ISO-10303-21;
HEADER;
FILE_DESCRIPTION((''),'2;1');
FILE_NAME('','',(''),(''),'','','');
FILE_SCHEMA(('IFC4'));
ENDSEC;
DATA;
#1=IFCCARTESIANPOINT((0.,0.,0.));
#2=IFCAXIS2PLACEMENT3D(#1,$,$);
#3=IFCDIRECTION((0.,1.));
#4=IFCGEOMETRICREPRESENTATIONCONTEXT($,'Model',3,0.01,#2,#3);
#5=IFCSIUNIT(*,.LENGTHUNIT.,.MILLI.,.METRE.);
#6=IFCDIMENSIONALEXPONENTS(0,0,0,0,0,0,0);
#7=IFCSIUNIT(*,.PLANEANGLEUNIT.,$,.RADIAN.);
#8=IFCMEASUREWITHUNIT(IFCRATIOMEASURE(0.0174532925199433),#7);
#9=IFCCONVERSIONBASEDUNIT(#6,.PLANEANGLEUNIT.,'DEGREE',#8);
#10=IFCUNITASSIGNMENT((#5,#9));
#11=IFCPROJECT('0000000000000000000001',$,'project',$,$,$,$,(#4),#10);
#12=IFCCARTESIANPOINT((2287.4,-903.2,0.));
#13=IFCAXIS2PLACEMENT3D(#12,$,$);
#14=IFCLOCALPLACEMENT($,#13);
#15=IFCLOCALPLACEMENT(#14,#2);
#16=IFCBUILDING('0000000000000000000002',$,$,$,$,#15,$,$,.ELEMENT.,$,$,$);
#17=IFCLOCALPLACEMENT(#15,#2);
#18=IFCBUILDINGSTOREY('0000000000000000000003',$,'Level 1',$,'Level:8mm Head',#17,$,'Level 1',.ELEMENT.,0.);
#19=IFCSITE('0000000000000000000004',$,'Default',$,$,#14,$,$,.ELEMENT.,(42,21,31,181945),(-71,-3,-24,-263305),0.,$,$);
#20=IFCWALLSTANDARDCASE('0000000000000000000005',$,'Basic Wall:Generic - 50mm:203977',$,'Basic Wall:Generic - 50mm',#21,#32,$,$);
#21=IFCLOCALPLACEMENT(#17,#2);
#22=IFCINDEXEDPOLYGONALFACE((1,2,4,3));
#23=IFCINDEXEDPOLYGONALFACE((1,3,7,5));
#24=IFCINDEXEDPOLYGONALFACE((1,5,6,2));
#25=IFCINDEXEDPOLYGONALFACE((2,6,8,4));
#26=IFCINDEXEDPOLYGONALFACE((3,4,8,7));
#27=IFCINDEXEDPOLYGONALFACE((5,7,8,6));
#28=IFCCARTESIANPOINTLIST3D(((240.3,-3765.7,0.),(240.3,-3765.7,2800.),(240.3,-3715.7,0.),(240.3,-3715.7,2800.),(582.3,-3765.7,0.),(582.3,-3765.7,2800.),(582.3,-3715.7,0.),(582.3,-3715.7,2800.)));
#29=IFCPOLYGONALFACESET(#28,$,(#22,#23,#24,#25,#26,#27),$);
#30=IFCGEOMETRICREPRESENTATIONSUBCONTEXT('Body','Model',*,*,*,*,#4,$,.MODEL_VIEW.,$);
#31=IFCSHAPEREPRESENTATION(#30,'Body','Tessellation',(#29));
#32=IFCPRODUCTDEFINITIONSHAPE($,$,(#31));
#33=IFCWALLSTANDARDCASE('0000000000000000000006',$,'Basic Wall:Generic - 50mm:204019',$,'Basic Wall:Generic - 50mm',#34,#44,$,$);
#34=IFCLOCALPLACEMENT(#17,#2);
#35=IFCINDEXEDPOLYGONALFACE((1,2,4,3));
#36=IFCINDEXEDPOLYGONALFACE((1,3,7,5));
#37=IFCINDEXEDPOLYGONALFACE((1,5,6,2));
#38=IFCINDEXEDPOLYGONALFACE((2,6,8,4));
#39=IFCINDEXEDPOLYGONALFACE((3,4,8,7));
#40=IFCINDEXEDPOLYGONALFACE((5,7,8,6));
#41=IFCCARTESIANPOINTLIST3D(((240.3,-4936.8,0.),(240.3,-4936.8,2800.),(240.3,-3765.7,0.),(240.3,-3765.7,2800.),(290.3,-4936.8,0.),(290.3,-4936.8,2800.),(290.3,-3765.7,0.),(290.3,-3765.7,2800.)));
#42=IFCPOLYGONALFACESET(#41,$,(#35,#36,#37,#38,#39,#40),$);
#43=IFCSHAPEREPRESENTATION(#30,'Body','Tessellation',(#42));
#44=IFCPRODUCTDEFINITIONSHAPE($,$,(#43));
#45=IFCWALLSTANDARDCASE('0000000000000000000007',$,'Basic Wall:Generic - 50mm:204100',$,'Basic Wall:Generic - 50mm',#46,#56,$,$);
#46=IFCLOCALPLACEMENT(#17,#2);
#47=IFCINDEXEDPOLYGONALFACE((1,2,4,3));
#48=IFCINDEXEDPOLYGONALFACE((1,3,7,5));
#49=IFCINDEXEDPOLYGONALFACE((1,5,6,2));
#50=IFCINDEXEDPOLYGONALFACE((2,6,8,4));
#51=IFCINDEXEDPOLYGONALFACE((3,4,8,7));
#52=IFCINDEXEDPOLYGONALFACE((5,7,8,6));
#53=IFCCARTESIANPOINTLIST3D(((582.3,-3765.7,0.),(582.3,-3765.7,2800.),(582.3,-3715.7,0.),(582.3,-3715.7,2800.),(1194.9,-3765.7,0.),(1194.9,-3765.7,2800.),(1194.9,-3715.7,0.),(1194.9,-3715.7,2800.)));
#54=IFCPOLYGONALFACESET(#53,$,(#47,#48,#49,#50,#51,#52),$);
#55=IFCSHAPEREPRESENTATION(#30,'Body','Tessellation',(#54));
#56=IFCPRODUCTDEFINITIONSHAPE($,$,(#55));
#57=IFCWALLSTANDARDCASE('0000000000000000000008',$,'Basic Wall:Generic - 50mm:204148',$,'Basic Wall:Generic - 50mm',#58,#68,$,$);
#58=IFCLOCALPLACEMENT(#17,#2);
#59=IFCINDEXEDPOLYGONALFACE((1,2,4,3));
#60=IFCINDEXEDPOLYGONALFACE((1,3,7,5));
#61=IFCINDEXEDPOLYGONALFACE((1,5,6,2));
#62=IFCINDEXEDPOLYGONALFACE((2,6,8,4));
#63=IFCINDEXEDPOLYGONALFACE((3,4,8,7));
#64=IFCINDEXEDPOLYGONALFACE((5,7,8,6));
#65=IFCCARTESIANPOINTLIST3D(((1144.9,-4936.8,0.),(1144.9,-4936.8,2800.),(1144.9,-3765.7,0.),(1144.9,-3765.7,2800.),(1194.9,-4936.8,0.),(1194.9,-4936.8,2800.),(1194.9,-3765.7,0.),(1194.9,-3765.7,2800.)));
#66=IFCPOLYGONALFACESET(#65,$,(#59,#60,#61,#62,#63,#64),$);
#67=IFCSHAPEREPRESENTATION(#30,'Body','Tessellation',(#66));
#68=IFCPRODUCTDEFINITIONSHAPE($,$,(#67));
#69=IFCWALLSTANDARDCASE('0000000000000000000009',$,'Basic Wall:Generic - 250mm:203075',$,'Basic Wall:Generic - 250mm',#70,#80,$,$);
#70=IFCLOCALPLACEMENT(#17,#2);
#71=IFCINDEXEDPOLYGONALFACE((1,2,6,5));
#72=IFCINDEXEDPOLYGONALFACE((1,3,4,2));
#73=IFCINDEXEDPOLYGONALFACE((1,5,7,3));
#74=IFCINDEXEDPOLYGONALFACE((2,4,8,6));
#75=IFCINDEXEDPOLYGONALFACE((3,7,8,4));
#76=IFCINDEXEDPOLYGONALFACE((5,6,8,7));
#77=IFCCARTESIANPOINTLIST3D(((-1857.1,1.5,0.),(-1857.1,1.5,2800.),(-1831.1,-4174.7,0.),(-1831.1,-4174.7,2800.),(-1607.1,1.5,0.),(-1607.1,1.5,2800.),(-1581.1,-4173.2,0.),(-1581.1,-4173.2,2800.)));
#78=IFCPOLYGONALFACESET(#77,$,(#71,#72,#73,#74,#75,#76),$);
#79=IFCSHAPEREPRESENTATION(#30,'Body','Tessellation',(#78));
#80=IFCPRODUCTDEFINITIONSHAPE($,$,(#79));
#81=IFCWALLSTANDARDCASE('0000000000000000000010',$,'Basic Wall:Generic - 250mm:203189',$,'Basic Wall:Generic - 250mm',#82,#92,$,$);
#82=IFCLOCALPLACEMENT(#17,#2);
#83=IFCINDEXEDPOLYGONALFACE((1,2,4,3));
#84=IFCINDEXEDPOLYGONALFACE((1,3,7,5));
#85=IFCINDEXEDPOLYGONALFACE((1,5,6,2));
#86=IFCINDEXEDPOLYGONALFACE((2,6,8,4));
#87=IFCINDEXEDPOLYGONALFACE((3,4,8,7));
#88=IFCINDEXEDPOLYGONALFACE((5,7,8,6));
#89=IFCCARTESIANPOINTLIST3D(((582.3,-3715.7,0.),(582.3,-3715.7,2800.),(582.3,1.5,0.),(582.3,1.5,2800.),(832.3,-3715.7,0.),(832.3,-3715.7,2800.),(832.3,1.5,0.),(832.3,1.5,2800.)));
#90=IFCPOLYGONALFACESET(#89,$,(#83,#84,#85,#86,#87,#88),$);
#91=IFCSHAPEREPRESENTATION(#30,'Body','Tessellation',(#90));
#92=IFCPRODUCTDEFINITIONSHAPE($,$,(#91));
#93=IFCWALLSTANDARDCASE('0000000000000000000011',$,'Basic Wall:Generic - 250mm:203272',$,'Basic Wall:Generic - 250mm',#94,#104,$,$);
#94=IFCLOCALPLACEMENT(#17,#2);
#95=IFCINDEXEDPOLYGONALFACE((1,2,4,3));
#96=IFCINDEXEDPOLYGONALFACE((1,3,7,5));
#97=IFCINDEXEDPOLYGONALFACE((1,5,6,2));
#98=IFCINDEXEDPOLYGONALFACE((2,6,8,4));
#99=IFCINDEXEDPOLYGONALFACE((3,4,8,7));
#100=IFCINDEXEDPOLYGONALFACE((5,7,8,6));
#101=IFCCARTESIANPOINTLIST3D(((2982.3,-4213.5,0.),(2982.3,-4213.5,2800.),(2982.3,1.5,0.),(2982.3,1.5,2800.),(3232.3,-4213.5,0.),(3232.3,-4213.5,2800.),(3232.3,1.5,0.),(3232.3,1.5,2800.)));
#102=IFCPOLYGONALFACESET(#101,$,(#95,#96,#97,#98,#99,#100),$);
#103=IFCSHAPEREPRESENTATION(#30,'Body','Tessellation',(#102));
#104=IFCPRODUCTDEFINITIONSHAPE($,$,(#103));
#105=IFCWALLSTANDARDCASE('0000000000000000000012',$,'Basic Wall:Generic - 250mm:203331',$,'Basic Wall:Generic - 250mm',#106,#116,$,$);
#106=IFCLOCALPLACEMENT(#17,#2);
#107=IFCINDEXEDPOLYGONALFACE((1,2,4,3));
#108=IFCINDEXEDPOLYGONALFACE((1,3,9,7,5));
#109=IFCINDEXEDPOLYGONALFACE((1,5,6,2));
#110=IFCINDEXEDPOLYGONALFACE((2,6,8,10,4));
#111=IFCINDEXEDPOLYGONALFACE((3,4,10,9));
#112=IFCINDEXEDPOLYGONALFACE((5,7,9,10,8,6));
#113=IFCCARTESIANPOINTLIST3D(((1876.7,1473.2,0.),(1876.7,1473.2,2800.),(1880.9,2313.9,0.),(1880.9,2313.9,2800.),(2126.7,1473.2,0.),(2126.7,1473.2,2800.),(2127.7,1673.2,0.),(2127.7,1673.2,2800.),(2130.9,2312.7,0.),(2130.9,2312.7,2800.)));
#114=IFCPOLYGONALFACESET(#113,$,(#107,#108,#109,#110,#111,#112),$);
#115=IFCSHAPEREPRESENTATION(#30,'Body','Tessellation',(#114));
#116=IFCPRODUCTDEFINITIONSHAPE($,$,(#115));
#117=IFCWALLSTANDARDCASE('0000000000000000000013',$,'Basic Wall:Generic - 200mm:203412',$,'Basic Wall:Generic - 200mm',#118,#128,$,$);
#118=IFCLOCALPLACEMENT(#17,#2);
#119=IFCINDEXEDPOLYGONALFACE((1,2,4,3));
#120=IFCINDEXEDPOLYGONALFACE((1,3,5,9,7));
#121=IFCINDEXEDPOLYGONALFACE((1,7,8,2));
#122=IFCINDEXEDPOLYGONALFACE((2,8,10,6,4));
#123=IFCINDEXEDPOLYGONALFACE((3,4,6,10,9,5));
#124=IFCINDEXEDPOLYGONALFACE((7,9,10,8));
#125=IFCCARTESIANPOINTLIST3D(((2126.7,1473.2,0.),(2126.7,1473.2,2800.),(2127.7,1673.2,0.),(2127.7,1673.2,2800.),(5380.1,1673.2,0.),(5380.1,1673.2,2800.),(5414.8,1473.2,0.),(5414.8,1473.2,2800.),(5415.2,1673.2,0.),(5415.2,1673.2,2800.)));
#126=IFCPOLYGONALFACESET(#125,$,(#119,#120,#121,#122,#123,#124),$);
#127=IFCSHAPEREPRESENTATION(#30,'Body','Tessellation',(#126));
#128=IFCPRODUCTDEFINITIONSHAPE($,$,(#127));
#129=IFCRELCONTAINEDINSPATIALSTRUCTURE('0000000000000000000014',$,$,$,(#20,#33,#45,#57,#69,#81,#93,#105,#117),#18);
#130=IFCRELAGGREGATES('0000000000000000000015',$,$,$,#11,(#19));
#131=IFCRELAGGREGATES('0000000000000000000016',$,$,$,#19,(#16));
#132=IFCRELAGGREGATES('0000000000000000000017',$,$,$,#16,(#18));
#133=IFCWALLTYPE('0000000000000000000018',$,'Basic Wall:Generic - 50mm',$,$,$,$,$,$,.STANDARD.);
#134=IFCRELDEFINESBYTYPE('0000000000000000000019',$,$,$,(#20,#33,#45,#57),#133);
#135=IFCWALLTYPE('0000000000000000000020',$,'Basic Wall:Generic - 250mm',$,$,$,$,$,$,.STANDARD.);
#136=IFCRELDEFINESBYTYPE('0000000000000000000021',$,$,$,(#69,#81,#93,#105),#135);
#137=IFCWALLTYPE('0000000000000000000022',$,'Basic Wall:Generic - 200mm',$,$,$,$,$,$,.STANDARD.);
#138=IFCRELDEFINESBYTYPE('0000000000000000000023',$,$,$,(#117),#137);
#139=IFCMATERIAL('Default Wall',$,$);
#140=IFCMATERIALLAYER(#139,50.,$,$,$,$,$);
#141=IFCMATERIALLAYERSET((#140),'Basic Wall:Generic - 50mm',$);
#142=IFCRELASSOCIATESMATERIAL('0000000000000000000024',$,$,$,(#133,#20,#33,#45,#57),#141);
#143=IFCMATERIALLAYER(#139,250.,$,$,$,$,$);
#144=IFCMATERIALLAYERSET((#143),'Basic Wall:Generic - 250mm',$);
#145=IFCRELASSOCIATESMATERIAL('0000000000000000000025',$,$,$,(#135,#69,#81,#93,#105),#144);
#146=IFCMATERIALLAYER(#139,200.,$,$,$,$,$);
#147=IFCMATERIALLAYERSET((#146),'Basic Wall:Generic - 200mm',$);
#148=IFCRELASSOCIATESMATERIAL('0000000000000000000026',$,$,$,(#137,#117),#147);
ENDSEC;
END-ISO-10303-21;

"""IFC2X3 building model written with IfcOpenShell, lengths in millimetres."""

from ifc_helpers import new_model, entity, si_unit, converted_unit, direction, frame, frame_2d, origin, place, context, subcontext, project, spatial, polyline, rectangle, outline, extrude, material, layer, layer_set, layer_usage, type_object, element, save


model = new_model("IFC2X3")

# Units and contexts
model_context = context("Model", 3, precision=0.01, world=origin(), true_north=direction((0.0, 1.0)))
body_context = subcontext(model_context, "Body", "Model", "MODEL_VIEW")
ifc_project = project(units=[si_unit("LENGTHUNIT", "METRE", prefix="MILLI"), converted_unit("PLANEANGLEUNIT", "DEGREE", entity("IfcRatioMeasure", 0.0174532925199433), si_unit("PLANEANGLEUNIT", "RADIAN"), dimensions=[0, 0, 0, 0, 0, 0, 0])], contexts=[model_context])

# Site, building, storey
site_placement = place(None, frame((2287.4, -903.2, 0.0)))
site = spatial("IfcSite", under=ifc_project, at=site_placement, Name="Default", CompositionType="ELEMENT", RefLatitude=(42, 21, 31, 181945), RefLongitude=(-71, -3, -24, -263305), RefElevation=0.0)
building_placement = place(site_placement, origin())
building = spatial("IfcBuilding", under=site, at=building_placement, CompositionType="ELEMENT")
storey_placement = place(building_placement, origin())
storey = spatial("IfcBuildingStorey", under=building, at=storey_placement, Name="Level 1", ObjectType="Level:8mm Head", LongName="Level 1", CompositionType="ELEMENT", Elevation=0.0)

# Walls
ifc_material_1 = material(Name="Default Wall")
ifc_layer_1 = layer(ifc_material_1, 50.0)
ifc_layer_set_1 = layer_set([ifc_layer_1], Name="Basic Wall:Generic - 50mm")
wall_type_1 = type_object("IfcWallType", Name="Basic Wall:Generic - 50mm", PredefinedType="STANDARD", material=ifc_layer_set_1)
ifc_layer_usage_1 = layer_usage(ifc_layer_set_1, "AXIS2", "POSITIVE", -25.0)
wall_1_placement = place(storey_placement, frame((582.3, -3740.7, 0.0), z_axis=(0.0, 0.0, 1.0), x_axis=(-1.0, 0.0, 0.0)))
element("IfcWallStandardCase", 1, at=wall_1_placement, inside=storey, type_object=wall_type_1, material=ifc_layer_usage_1, Name="Basic Wall:Generic - 50mm:203977", ObjectType="Basic Wall:Generic - 50mm", context=body_context, shape_type="SweptSolid", body=[
    extrude(rectangle(XDim=342.1, YDim=50.0, at=frame_2d((171.0, 0.0), x_axis=(-1.0, 0.0))), origin(), (0.0, 0.0, 1.0), 2800.0),
])
ifc_layer_usage_2 = layer_usage(ifc_layer_set_1, "AXIS2", "POSITIVE", -25.0)
wall_2_placement = place(storey_placement, frame((265.3, -3765.7, 0.0), z_axis=(0.0, 0.0, 1.0), x_axis=(0.0, -1.0, 0.0)))
element("IfcWallStandardCase", 2, at=wall_2_placement, inside=storey, type_object=wall_type_1, material=ifc_layer_usage_2, Name="Basic Wall:Generic - 50mm:204019", ObjectType="Basic Wall:Generic - 50mm", context=body_context, shape_type="SweptSolid", body=[
    extrude(rectangle(XDim=1171.1, YDim=50.0, at=frame_2d((585.5, 0.0), x_axis=(-1.0, 0.0))), origin(), (0.0, 0.0, 1.0), 2800.0),
])
ifc_layer_usage_3 = layer_usage(ifc_layer_set_1, "AXIS2", "POSITIVE", -25.0)
wall_3_placement = place(storey_placement, frame((582.3, -3740.7, 0.0)))
element("IfcWallStandardCase", 3, at=wall_3_placement, inside=storey, type_object=wall_type_1, material=ifc_layer_usage_3, Name="Basic Wall:Generic - 50mm:204100", ObjectType="Basic Wall:Generic - 50mm", context=body_context, shape_type="SweptSolid", body=[
    extrude(rectangle(XDim=612.6, YDim=50.0, at=frame_2d((306.3, 0.0), x_axis=(-1.0, 0.0))), origin(), (0.0, 0.0, 1.0), 2800.0),
])
ifc_layer_usage_4 = layer_usage(ifc_layer_set_1, "AXIS2", "NEGATIVE", 25.0)
wall_4_placement = place(storey_placement, frame((1169.9, -3765.7, 0.0), z_axis=(0.0, 0.0, 1.0), x_axis=(0.0, -1.0, 0.0)))
element("IfcWallStandardCase", 4, at=wall_4_placement, inside=storey, type_object=wall_type_1, material=ifc_layer_usage_4, Name="Basic Wall:Generic - 50mm:204148", ObjectType="Basic Wall:Generic - 50mm", context=body_context, shape_type="SweptSolid", body=[
    extrude(rectangle(XDim=1171.1, YDim=50.0, at=frame_2d((585.5, 0.0), x_axis=(-1.0, 0.0))), origin(), (0.0, 0.0, 1.0), 2800.0),
])
ifc_layer_2 = layer(ifc_material_1, 250.0)
ifc_layer_set_2 = layer_set([ifc_layer_2], Name="Basic Wall:Generic - 250mm")
ifc_layer_usage_5 = layer_usage(ifc_layer_set_2, "AXIS2", "POSITIVE", -125.0)
wall_type_2 = type_object("IfcWallType", Name="Basic Wall:Generic - 250mm", PredefinedType="STANDARD", material=ifc_layer_set_2)
wall_5_placement = place(storey_placement, frame((-1732.1, 2.3, 0.0), z_axis=(0.0, 0.0, 1.0), x_axis=(0.006231, -0.999981, 0.0)))
element("IfcWallStandardCase", 5, at=wall_5_placement, inside=storey, type_object=wall_type_2, material=ifc_layer_usage_5, Name="Basic Wall:Generic - 250mm:203075", ObjectType="Basic Wall:Generic - 250mm", context=body_context, shape_type="SweptSolid", body=[
    extrude(outline(polyline([(4176.3, -125.0), (4176.3, 125.0), (1.6, 125.0), (0.0, -125.0), (4176.3, -125.0)])), origin(), (0.0, 0.0, 1.0), 2800.0),
])
ifc_layer_usage_6 = layer_usage(ifc_layer_set_2, "AXIS2", "POSITIVE", -125.0)
wall_6_placement = place(storey_placement, frame((707.3, 1.5, 0.0), z_axis=(0.0, 0.0, 1.0), x_axis=(0.0, -1.0, 0.0)))
element("IfcWallStandardCase", 6, at=wall_6_placement, inside=storey, type_object=wall_type_2, material=ifc_layer_usage_6, Name="Basic Wall:Generic - 250mm:203189", ObjectType="Basic Wall:Generic - 250mm", context=body_context, shape_type="SweptSolid", body=[
    extrude(rectangle(XDim=3717.2, YDim=250.0, at=frame_2d((1858.6, 0.0), x_axis=(-1.0, 0.0))), origin(), (0.0, 0.0, 1.0), 2800.0),
])
ifc_layer_usage_7 = layer_usage(ifc_layer_set_2, "AXIS2", "POSITIVE", -125.0)
wall_7_placement = place(storey_placement, frame((3107.3, 1.5, 0.0), z_axis=(0.0, 0.0, 1.0), x_axis=(0.0, -1.0, 0.0)))
element("IfcWallStandardCase", 7, at=wall_7_placement, inside=storey, type_object=wall_type_2, material=ifc_layer_usage_7, Name="Basic Wall:Generic - 250mm:203272", ObjectType="Basic Wall:Generic - 250mm", context=body_context, shape_type="SweptSolid", body=[
    extrude(rectangle(XDim=4215.0, YDim=250.0, at=frame_2d((2107.5, 0.0), x_axis=(-1.0, 0.0))), origin(), (0.0, 0.0, 1.0), 2800.0),
])
ifc_layer_usage_8 = layer_usage(ifc_layer_set_2, "AXIS2", "POSITIVE", -125.0)
wall_8_placement = place(storey_placement, frame((2005.9, 2313.3, 0.0), z_axis=(0.0, 0.0, 1.0), x_axis=(-0.00502, -0.999987, 0.0)))
element("IfcWallStandardCase", 8, at=wall_8_placement, inside=storey, type_object=wall_type_2, material=ifc_layer_usage_8, Name="Basic Wall:Generic - 250mm:203331", ObjectType="Basic Wall:Generic - 250mm", context=body_context, shape_type="SweptSolid", body=[
    extrude(outline(polyline([(840.8, -125.0), (839.5, 125.0), (639.5, 125.0), (0.0, 125.0), (0.0, -125.0), (840.8, -125.0)])), origin(), (0.0, 0.0, 1.0), 2800.0),
])
ifc_layer_3 = layer(ifc_material_1, 200.0)
ifc_layer_set_3 = layer_set([ifc_layer_3], Name="Basic Wall:Generic - 200mm")
ifc_layer_usage_9 = layer_usage(ifc_layer_set_3, "AXIS2", "POSITIVE", -100.0)
wall_type_3 = type_object("IfcWallType", Name="Basic Wall:Generic - 200mm", PredefinedType="STANDARD", material=ifc_layer_set_3)
wall_9_placement = place(storey_placement, frame((2126.7, 1573.2, 0.0)))
element("IfcWallStandardCase", 9, at=wall_9_placement, inside=storey, type_object=wall_type_3, material=ifc_layer_usage_9, Name="Basic Wall:Generic - 200mm:203412", ObjectType="Basic Wall:Generic - 200mm", context=body_context, shape_type="SweptSolid", body=[
    extrude(outline(polyline([(3288.1, -100.0), (3288.6, 100.0), (3253.4, 100.0), (1.0, 100.0), (0.0, -100.0), (3288.1, -100.0)])), origin(), (0.0, 0.0, 1.0), 2800.0),
])

save(model, "model.ifc")
